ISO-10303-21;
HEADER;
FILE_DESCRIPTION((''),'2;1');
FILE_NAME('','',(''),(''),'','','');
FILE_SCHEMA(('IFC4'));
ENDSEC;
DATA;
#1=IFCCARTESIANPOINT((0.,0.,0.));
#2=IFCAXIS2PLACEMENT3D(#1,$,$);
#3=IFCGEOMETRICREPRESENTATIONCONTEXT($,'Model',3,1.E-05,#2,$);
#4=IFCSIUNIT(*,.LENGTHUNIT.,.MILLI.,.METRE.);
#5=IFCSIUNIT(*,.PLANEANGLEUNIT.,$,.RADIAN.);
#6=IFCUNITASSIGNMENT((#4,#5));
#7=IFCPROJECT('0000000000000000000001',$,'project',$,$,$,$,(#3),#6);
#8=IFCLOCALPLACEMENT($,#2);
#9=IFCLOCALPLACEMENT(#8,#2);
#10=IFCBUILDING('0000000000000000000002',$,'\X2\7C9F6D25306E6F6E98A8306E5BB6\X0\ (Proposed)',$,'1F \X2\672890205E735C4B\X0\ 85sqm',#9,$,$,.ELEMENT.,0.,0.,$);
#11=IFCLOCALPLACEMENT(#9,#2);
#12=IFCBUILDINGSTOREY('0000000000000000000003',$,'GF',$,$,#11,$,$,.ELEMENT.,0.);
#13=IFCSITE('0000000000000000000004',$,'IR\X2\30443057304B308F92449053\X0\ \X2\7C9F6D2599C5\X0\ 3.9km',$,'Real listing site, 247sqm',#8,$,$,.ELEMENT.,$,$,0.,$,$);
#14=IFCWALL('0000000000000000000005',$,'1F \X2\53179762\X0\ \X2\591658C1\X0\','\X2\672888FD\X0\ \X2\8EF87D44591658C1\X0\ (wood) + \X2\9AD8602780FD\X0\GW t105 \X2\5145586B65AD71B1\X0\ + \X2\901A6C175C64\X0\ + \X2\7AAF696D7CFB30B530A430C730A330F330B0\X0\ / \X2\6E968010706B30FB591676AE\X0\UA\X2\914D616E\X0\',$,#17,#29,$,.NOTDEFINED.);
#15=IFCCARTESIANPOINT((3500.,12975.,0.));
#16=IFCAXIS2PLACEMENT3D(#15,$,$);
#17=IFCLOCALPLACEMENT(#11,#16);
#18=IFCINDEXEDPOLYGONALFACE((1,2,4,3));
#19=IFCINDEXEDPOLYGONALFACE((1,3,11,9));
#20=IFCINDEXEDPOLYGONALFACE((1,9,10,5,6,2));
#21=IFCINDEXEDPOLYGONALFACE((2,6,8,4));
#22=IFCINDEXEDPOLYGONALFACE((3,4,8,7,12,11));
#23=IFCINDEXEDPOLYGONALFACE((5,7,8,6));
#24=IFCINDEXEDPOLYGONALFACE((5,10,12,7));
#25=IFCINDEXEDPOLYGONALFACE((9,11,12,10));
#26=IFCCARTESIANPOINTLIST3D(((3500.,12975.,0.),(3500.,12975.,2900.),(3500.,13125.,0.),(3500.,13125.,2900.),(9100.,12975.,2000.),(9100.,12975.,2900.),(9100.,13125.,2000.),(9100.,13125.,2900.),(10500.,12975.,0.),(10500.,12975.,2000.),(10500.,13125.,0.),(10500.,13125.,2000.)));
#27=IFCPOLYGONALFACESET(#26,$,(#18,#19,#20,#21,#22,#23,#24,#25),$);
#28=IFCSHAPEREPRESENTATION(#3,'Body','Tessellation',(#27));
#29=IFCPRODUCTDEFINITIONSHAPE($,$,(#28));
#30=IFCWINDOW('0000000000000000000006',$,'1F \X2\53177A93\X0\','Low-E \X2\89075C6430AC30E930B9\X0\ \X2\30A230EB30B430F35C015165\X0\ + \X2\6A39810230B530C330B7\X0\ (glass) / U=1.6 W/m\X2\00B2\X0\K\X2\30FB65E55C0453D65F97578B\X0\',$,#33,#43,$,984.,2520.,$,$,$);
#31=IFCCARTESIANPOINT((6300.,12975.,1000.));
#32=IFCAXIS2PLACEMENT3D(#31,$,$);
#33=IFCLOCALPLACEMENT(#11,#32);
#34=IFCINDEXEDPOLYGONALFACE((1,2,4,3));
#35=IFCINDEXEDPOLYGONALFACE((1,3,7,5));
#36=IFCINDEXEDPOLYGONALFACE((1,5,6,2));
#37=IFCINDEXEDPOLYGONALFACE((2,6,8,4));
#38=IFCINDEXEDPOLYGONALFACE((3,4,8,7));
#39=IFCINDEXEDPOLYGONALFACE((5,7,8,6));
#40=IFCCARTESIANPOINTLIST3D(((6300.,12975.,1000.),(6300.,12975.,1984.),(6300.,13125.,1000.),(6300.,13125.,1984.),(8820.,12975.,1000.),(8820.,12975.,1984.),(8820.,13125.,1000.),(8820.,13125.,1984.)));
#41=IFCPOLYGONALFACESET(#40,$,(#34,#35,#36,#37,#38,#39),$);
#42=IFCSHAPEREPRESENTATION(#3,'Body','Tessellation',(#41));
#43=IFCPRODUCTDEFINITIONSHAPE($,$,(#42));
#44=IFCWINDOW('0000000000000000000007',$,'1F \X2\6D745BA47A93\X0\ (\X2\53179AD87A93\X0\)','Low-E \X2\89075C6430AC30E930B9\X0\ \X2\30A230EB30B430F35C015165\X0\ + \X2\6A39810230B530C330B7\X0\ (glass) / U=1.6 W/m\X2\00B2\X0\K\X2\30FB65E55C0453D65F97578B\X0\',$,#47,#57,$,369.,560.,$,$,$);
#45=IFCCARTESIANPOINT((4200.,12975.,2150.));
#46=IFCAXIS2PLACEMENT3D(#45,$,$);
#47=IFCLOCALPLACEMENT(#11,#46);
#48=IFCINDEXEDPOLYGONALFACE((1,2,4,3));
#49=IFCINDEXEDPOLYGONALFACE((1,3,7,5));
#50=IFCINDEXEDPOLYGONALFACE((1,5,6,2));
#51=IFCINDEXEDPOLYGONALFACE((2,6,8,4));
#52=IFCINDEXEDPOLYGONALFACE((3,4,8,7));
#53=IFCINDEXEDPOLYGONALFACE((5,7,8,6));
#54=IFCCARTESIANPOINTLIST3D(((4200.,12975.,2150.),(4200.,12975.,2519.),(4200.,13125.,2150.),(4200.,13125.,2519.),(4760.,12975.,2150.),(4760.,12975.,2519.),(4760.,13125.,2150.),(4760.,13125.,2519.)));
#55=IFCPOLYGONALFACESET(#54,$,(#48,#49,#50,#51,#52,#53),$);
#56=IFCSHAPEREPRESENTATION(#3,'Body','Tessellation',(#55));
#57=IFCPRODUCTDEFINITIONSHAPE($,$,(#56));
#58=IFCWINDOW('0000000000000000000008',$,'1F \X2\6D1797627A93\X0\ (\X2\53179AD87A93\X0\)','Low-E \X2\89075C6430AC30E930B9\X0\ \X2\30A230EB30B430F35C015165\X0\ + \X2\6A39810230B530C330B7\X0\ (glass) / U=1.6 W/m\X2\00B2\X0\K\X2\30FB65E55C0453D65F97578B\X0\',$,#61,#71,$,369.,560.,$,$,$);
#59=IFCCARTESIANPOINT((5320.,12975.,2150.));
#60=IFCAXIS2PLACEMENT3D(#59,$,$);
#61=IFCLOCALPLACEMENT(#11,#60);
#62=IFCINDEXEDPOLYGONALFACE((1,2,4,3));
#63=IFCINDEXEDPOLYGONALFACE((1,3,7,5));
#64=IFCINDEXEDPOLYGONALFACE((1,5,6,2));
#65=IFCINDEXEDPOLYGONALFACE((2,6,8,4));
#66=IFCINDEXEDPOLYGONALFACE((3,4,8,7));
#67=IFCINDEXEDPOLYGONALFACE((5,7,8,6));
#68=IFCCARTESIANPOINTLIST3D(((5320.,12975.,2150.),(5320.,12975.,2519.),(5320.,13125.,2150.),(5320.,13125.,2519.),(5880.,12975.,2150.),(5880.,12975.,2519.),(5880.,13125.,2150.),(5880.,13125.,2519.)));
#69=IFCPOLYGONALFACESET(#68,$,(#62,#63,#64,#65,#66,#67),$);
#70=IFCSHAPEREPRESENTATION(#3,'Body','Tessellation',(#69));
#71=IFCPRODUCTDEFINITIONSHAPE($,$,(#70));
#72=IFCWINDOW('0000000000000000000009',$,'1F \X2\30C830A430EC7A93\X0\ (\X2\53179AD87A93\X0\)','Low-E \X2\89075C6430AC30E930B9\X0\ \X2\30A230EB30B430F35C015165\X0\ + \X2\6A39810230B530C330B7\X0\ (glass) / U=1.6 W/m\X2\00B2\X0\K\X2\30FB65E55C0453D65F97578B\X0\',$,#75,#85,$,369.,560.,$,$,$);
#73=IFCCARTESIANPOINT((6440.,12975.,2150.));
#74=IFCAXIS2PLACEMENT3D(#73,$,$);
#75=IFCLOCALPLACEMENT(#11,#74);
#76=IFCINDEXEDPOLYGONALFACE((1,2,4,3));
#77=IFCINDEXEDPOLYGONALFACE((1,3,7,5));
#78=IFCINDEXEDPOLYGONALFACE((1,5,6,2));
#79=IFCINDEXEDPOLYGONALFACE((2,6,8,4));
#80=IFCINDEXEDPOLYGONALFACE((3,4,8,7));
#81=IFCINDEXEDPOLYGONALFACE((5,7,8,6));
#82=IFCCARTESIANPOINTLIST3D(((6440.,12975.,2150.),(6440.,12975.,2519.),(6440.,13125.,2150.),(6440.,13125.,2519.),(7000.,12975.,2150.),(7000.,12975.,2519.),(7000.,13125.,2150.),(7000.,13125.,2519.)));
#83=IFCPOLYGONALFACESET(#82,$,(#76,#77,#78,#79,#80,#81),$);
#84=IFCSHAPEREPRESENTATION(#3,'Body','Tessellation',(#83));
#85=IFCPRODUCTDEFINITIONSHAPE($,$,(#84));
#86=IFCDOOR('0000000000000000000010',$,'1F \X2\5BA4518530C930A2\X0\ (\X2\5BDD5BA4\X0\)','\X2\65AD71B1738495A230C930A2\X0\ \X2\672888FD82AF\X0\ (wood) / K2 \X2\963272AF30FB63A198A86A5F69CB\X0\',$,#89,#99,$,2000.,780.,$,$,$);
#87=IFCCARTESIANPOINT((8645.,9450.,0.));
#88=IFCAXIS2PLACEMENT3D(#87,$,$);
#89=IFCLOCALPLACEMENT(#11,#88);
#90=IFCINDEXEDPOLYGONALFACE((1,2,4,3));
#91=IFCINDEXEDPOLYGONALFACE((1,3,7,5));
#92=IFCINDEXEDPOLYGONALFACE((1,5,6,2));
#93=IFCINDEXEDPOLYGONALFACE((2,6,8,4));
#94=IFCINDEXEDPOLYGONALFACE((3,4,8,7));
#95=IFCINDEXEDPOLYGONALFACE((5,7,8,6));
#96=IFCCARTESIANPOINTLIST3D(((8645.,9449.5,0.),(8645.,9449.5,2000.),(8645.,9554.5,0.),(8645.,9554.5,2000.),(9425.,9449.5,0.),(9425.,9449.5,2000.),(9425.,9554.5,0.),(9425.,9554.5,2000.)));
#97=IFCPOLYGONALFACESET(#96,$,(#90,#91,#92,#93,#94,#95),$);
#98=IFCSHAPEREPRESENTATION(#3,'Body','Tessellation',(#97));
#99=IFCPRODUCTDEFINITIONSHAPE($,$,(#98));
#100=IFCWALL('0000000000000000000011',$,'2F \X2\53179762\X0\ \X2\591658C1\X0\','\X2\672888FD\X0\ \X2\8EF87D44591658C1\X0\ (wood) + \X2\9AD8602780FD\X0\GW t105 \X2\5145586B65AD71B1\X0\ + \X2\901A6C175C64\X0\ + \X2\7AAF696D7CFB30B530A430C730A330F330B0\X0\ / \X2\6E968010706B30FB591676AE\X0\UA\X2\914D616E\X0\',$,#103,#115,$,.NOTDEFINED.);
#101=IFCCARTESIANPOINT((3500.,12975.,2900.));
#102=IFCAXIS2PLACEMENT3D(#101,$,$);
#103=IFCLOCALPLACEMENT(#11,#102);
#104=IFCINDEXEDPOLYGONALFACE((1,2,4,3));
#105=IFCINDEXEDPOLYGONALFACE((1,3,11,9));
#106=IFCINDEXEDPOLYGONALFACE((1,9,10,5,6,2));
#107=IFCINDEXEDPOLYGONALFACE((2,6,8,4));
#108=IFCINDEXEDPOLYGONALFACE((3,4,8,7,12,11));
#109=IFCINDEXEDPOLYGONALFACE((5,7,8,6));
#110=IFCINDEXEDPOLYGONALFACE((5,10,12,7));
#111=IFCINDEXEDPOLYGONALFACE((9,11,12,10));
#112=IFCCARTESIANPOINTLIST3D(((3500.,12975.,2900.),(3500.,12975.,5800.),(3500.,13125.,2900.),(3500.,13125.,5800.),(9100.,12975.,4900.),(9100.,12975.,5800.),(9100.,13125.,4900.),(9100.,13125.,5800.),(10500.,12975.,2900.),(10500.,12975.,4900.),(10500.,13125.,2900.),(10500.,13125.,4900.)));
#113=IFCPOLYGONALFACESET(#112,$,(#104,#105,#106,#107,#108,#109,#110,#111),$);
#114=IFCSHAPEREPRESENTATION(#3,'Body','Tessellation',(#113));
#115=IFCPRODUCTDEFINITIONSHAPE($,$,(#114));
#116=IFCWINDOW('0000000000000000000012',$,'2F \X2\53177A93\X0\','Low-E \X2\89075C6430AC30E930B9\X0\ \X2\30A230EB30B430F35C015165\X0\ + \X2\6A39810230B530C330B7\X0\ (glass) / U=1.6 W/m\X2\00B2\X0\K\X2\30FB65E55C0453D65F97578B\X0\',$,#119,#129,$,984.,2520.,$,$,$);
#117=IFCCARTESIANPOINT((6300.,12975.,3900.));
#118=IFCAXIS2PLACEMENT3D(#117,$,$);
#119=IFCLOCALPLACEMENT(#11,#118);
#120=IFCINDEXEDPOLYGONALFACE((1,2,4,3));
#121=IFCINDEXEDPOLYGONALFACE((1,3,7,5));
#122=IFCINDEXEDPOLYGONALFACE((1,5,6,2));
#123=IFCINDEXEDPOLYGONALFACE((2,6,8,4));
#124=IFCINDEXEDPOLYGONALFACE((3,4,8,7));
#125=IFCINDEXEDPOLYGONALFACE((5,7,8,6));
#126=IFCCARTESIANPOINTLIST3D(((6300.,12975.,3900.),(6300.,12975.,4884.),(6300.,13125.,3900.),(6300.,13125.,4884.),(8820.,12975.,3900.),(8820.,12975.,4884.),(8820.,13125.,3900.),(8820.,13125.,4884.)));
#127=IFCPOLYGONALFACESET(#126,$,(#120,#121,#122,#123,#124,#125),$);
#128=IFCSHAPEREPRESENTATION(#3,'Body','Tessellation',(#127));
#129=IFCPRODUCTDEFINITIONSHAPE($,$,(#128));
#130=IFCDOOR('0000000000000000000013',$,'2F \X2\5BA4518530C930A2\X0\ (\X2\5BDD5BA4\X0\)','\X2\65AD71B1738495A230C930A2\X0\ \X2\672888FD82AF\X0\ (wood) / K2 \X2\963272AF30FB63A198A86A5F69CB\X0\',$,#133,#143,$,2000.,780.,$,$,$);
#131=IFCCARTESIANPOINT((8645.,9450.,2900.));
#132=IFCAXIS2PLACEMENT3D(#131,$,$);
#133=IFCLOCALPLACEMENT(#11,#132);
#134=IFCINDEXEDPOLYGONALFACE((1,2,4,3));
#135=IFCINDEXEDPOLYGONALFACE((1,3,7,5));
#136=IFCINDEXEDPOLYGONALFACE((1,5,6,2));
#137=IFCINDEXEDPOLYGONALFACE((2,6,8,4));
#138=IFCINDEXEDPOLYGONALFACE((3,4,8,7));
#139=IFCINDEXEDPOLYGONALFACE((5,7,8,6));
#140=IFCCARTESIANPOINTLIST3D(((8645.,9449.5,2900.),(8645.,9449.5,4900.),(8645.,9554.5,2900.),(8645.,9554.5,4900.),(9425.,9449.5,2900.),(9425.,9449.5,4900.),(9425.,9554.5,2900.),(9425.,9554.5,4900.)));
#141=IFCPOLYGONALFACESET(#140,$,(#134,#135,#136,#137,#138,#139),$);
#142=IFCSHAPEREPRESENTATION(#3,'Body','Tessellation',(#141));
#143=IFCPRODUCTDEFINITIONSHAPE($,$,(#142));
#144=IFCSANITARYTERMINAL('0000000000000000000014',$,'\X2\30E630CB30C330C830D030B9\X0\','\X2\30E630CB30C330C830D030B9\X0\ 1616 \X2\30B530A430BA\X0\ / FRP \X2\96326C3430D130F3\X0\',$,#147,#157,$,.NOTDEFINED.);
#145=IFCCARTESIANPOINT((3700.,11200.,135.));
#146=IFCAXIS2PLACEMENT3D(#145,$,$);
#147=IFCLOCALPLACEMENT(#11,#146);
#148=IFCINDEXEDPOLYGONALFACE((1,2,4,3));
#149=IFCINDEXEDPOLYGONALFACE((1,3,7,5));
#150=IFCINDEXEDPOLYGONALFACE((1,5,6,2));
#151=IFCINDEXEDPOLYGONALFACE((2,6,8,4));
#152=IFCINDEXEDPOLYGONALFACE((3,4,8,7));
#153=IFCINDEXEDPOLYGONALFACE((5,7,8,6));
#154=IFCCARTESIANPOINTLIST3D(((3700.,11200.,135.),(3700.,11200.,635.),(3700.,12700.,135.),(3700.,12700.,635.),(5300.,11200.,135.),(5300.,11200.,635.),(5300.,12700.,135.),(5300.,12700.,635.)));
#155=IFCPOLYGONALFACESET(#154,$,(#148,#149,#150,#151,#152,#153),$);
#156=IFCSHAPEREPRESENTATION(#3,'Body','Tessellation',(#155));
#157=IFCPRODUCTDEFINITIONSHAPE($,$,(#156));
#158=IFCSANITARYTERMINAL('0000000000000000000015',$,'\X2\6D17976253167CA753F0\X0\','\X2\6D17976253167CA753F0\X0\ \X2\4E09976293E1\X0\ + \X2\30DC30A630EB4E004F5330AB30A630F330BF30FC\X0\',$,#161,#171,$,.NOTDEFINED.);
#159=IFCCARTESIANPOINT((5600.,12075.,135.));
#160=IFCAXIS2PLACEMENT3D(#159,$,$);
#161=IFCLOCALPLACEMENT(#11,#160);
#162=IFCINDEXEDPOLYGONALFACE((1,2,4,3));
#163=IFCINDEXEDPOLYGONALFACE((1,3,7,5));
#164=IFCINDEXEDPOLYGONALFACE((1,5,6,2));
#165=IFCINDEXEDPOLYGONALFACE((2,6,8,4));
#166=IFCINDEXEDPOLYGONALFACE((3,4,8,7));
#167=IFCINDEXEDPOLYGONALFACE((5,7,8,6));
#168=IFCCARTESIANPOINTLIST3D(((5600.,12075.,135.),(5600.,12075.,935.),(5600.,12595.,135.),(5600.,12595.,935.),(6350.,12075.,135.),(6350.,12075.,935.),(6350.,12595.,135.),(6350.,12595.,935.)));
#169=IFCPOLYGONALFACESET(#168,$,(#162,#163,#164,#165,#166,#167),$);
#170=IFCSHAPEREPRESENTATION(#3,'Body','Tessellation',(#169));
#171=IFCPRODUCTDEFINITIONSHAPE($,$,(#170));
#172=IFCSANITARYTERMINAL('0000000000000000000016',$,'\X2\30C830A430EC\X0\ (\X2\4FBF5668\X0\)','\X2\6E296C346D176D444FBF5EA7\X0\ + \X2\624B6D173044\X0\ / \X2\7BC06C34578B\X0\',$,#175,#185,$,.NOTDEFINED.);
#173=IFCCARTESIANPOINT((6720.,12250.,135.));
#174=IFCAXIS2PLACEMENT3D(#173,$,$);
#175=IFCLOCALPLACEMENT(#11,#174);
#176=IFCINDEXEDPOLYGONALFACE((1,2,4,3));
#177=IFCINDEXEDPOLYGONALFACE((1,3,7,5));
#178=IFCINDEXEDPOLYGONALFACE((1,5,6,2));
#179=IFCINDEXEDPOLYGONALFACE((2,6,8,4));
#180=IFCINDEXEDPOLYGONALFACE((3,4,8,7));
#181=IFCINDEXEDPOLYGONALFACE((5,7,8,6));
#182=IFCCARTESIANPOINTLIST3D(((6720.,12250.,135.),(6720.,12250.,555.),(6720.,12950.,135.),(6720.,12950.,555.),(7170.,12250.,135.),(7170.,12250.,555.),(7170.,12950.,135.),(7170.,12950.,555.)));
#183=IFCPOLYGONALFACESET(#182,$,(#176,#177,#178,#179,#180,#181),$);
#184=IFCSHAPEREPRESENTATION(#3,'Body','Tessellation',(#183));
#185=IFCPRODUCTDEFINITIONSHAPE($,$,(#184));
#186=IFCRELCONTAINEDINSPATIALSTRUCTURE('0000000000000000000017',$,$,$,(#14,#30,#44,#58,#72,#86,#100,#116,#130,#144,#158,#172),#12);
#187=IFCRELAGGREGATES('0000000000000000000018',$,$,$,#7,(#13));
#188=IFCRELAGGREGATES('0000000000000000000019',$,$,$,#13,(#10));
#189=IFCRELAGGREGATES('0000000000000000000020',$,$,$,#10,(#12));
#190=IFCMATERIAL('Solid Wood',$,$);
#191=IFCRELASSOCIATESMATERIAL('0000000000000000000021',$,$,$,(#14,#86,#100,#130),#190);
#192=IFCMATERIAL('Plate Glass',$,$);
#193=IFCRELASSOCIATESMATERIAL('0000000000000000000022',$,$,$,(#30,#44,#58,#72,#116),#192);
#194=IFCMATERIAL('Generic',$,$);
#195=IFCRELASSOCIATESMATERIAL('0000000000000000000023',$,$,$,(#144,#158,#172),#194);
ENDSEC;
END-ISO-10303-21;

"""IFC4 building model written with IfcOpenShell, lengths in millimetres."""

from ifc_helpers import new_model, si_unit, frame, frame_2d, origin, place, context, project, spatial, rectangle, extrude, material, element, fill, save


model = new_model("IFC4")

# Units and contexts
model_context = context("Model", 3, precision=1e-05, world=origin())
ifc_project = project(units=[si_unit("LENGTHUNIT", "METRE", prefix="MILLI"), si_unit("PLANEANGLEUNIT", "RADIAN")], contexts=[model_context])

# Site, building, storey
site_placement = place(None, origin())
site = spatial("IfcSite", under=ifc_project, at=site_placement, Name="IRいしかわ鉄道 粟津駅 3.9km", ObjectType="Real listing site, 247sqm", CompositionType="ELEMENT", RefElevation=0.0)
building_placement = place(site_placement, origin())
building = spatial("IfcBuilding", under=site, at=building_placement, Name="粟津の潮風の家 (Proposed)", ObjectType="1F 木造平屋 85sqm", CompositionType="ELEMENT", ElevationOfRefHeight=0.0, ElevationOfTerrain=0.0)
storey_placement = place(building_placement, origin())
storey = spatial("IfcBuildingStorey", under=building, at=storey_placement, Name="GF", CompositionType="ELEMENT", Elevation=0.0)

# Wall, openings, windows
ifc_material_1 = material(Name="Solid Wood")
wall_1_placement = place(storey_placement, frame((3500.0, 12975.0, 0.0)))
wall_1 = element("IfcWall", 1, at=wall_1_placement, inside=storey, material=ifc_material_1, Name="1F 北面 外壁", Description="木製 軸組外壁 (wood) + 高性能GW t105 充填断熱 + 通気層 + 窯業系サイディング / 準耐火・外皮UA配慮", PredefinedType="NOTDEFINED", context=model_context, shape_type="SweptSolid", body=[
    extrude(rectangle(XDim=7000.0, YDim=150.0, at=frame_2d((3500.0, 75.0))), frame((3500.0, 12975.0, 0.0)), (0.0, 0.0, 1.0), 2900.0),
])
opening_1_placement = place(storey_placement, frame((6300.0, 12975.0, 1000.0)))
opening_1 = element("IfcOpeningElement", 2, at=opening_1_placement, cuts=wall_1, PredefinedType="NOTDEFINED", context=model_context, shape_type="SweptSolid", body=[
    extrude(rectangle(XDim=2520.0, YDim=150.0, at=frame_2d((1260.0, 75.0))), frame((6300.0, 12975.0, 1000.0)), (0.0, 0.0, 1.0), 984.0),
])
opening_2_placement = place(storey_placement, frame((4200.0, 12975.0, 2150.0)))
opening_2 = element("IfcOpeningElement", 3, at=opening_2_placement, cuts=wall_1, PredefinedType="NOTDEFINED", context=model_context, shape_type="SweptSolid", body=[
    extrude(rectangle(XDim=560.0, YDim=150.0, at=frame_2d((280.0, 75.0))), frame((4200.0, 12975.0, 2150.0)), (0.0, 0.0, 1.0), 369.0),
])
opening_3_placement = place(storey_placement, frame((5320.0, 12975.0, 2150.0)))
opening_3 = element("IfcOpeningElement", 4, at=opening_3_placement, cuts=wall_1, PredefinedType="NOTDEFINED", context=model_context, shape_type="SweptSolid", body=[
    extrude(rectangle(XDim=560.0, YDim=150.0, at=frame_2d((280.0, 75.0))), frame((5320.0, 12975.0, 2150.0)), (0.0, 0.0, 1.0), 369.0),
])
opening_4_placement = place(storey_placement, frame((6440.0, 12975.0, 2150.0)))
opening_4 = element("IfcOpeningElement", 5, at=opening_4_placement, cuts=wall_1, PredefinedType="NOTDEFINED", context=model_context, shape_type="SweptSolid", body=[
    extrude(rectangle(XDim=560.0, YDim=150.0, at=frame_2d((280.0, 75.0))), frame((6440.0, 12975.0, 2150.0)), (0.0, 0.0, 1.0), 369.0),
])
ifc_material_2 = material(Name="Plate Glass")
window_1_placement = place(storey_placement, frame((6300.0, 12975.0, 1000.0)))
window_1 = element("IfcWindow", 6, at=window_1_placement, inside=storey, material=ifc_material_2, Name="1F 北窓", Description="Low-E 複層ガラス アルゴン封入 + 樹脂サッシ (glass) / U=1.6 W/m²K・日射取得型", OverallHeight=984.0, OverallWidth=2520.0, context=model_context, shape_type="SweptSolid", body=[
    extrude(rectangle(XDim=2520.0, YDim=150.0, at=frame_2d((1260.0, 75.0))), frame((6300.0, 12975.0, 1000.0)), (0.0, 0.0, 1.0), 984.0),
])
fill(opening_1, window_1)
window_2_placement = place(storey_placement, frame((4200.0, 12975.0, 2150.0)))
window_2 = element("IfcWindow", 7, at=window_2_placement, inside=storey, material=ifc_material_2, Name="1F 浴室窓 (北高窓)", Description="Low-E 複層ガラス アルゴン封入 + 樹脂サッシ (glass) / U=1.6 W/m²K・日射取得型", OverallHeight=369.0, OverallWidth=560.0, context=model_context, shape_type="SweptSolid", body=[
    extrude(rectangle(XDim=560.0, YDim=150.0, at=frame_2d((280.0, 75.0))), frame((4200.0, 12975.0, 2150.0)), (0.0, 0.0, 1.0), 369.0),
])
fill(opening_2, window_2)
window_3_placement = place(storey_placement, frame((5320.0, 12975.0, 2150.0)))
window_3 = element("IfcWindow", 8, at=window_3_placement, inside=storey, material=ifc_material_2, Name="1F 洗面窓 (北高窓)", Description="Low-E 複層ガラス アルゴン封入 + 樹脂サッシ (glass) / U=1.6 W/m²K・日射取得型", OverallHeight=369.0, OverallWidth=560.0, context=model_context, shape_type="SweptSolid", body=[
    extrude(rectangle(XDim=560.0, YDim=150.0, at=frame_2d((280.0, 75.0))), frame((5320.0, 12975.0, 2150.0)), (0.0, 0.0, 1.0), 369.0),
])
fill(opening_3, window_3)
window_4_placement = place(storey_placement, frame((6440.0, 12975.0, 2150.0)))
window_4 = element("IfcWindow", 9, at=window_4_placement, inside=storey, material=ifc_material_2, Name="1F トイレ窓 (北高窓)", Description="Low-E 複層ガラス アルゴン封入 + 樹脂サッシ (glass) / U=1.6 W/m²K・日射取得型", OverallHeight=369.0, OverallWidth=560.0, context=model_context, shape_type="SweptSolid", body=[
    extrude(rectangle(XDim=560.0, YDim=150.0, at=frame_2d((280.0, 75.0))), frame((6440.0, 12975.0, 2150.0)), (0.0, 0.0, 1.0), 369.0),
])
fill(opening_4, window_4)

# Door
door_1_placement = place(storey_placement, frame((8645.0, 9450.0, 0.0)))
element("IfcDoor", 10, at=door_1_placement, inside=storey, material=ifc_material_1, Name="1F 室内ドア (寝室)", Description="断熱玄関ドア 木製芯 (wood) / K2 防犯・採風機構", OverallHeight=2000.0, OverallWidth=780.0, context=model_context, shape_type="SweptSolid", body=[
    extrude(rectangle(XDim=780.0, YDim=105.0, at=frame_2d((390.0, 52.0))), frame((8645.0, 9450.0, 0.0)), (0.0, 0.0, 1.0), 2000.0),
])

# Wall, opening, window
wall_2_placement = place(storey_placement, frame((3500.0, 12975.0, 2900.0)))
wall_2 = element("IfcWall", 11, at=wall_2_placement, inside=storey, material=ifc_material_1, Name="2F 北面 外壁", Description="木製 軸組外壁 (wood) + 高性能GW t105 充填断熱 + 通気層 + 窯業系サイディング / 準耐火・外皮UA配慮", PredefinedType="NOTDEFINED", context=model_context, shape_type="SweptSolid", body=[
    extrude(rectangle(XDim=7000.0, YDim=150.0, at=frame_2d((3500.0, 75.0))), frame((3500.0, 12975.0, 2900.0)), (0.0, 0.0, 1.0), 2900.0),
])
opening_5_placement = place(storey_placement, frame((6300.0, 12975.0, 3900.0)))
opening_5 = element("IfcOpeningElement", 12, at=opening_5_placement, cuts=wall_2, PredefinedType="NOTDEFINED", context=model_context, shape_type="SweptSolid", body=[
    extrude(rectangle(XDim=2520.0, YDim=150.0, at=frame_2d((1260.0, 75.0))), frame((6300.0, 12975.0, 3900.0)), (0.0, 0.0, 1.0), 984.0),
])
window_5_placement = place(storey_placement, frame((6300.0, 12975.0, 3900.0)))
window_5 = element("IfcWindow", 13, at=window_5_placement, inside=storey, material=ifc_material_2, Name="2F 北窓", Description="Low-E 複層ガラス アルゴン封入 + 樹脂サッシ (glass) / U=1.6 W/m²K・日射取得型", OverallHeight=984.0, OverallWidth=2520.0, context=model_context, shape_type="SweptSolid", body=[
    extrude(rectangle(XDim=2520.0, YDim=150.0, at=frame_2d((1260.0, 75.0))), frame((6300.0, 12975.0, 3900.0)), (0.0, 0.0, 1.0), 984.0),
])
fill(opening_5, window_5)

# Door
door_2_placement = place(storey_placement, frame((8645.0, 9450.0, 2900.0)))
element("IfcDoor", 14, at=door_2_placement, inside=storey, material=ifc_material_1, Name="2F 室内ドア (寝室)", Description="断熱玄関ドア 木製芯 (wood) / K2 防犯・採風機構", OverallHeight=2000.0, OverallWidth=780.0, context=model_context, shape_type="SweptSolid", body=[
    extrude(rectangle(XDim=780.0, YDim=105.0, at=frame_2d((390.0, 52.0))), frame((8645.0, 9450.0, 2900.0)), (0.0, 0.0, 1.0), 2000.0),
])

# Sanitary terminals
ifc_material_3 = material(Name="Generic")
sanitary_terminal_1_placement = place(storey_placement, frame((3700.0, 11200.0, 135.0)))
element("IfcSanitaryTerminal", 15, at=sanitary_terminal_1_placement, inside=storey, material=ifc_material_3, Name="ユニットバス", Description="ユニットバス 1616 サイズ / FRP 防水パン", PredefinedType="NOTDEFINED", context=model_context, shape_type="SweptSolid", body=[
    extrude(rectangle(XDim=1600.0, YDim=1500.0, at=frame_2d((800.0, 750.0))), frame((3700.0, 11200.0, 135.0)), (0.0, 0.0, 1.0), 500.0),
])
sanitary_terminal_2_placement = place(storey_placement, frame((5600.0, 12075.0, 135.0)))
element("IfcSanitaryTerminal", 16, at=sanitary_terminal_2_placement, inside=storey, material=ifc_material_3, Name="洗面化粧台", Description="洗面化粧台 三面鏡 + ボウル一体カウンター", PredefinedType="NOTDEFINED", context=model_context, shape_type="SweptSolid", body=[
    extrude(rectangle(XDim=750.0, YDim=520.0, at=frame_2d((375.0, 260.0))), frame((5600.0, 12075.0, 135.0)), (0.0, 0.0, 1.0), 800.0),
])
sanitary_terminal_3_placement = place(storey_placement, frame((6720.0, 12250.0, 135.0)))
element("IfcSanitaryTerminal", 17, at=sanitary_terminal_3_placement, inside=storey, material=ifc_material_3, Name="トイレ (便器)", Description="温水洗浄便座 + 手洗い / 節水型", PredefinedType="NOTDEFINED", context=model_context, shape_type="SweptSolid", body=[
    extrude(rectangle(XDim=450.0, YDim=700.0, at=frame_2d((225.0, 350.0))), frame((6720.0, 12250.0, 135.0)), (0.0, 0.0, 1.0), 420.0),
])

save(model, "model.ifc")
